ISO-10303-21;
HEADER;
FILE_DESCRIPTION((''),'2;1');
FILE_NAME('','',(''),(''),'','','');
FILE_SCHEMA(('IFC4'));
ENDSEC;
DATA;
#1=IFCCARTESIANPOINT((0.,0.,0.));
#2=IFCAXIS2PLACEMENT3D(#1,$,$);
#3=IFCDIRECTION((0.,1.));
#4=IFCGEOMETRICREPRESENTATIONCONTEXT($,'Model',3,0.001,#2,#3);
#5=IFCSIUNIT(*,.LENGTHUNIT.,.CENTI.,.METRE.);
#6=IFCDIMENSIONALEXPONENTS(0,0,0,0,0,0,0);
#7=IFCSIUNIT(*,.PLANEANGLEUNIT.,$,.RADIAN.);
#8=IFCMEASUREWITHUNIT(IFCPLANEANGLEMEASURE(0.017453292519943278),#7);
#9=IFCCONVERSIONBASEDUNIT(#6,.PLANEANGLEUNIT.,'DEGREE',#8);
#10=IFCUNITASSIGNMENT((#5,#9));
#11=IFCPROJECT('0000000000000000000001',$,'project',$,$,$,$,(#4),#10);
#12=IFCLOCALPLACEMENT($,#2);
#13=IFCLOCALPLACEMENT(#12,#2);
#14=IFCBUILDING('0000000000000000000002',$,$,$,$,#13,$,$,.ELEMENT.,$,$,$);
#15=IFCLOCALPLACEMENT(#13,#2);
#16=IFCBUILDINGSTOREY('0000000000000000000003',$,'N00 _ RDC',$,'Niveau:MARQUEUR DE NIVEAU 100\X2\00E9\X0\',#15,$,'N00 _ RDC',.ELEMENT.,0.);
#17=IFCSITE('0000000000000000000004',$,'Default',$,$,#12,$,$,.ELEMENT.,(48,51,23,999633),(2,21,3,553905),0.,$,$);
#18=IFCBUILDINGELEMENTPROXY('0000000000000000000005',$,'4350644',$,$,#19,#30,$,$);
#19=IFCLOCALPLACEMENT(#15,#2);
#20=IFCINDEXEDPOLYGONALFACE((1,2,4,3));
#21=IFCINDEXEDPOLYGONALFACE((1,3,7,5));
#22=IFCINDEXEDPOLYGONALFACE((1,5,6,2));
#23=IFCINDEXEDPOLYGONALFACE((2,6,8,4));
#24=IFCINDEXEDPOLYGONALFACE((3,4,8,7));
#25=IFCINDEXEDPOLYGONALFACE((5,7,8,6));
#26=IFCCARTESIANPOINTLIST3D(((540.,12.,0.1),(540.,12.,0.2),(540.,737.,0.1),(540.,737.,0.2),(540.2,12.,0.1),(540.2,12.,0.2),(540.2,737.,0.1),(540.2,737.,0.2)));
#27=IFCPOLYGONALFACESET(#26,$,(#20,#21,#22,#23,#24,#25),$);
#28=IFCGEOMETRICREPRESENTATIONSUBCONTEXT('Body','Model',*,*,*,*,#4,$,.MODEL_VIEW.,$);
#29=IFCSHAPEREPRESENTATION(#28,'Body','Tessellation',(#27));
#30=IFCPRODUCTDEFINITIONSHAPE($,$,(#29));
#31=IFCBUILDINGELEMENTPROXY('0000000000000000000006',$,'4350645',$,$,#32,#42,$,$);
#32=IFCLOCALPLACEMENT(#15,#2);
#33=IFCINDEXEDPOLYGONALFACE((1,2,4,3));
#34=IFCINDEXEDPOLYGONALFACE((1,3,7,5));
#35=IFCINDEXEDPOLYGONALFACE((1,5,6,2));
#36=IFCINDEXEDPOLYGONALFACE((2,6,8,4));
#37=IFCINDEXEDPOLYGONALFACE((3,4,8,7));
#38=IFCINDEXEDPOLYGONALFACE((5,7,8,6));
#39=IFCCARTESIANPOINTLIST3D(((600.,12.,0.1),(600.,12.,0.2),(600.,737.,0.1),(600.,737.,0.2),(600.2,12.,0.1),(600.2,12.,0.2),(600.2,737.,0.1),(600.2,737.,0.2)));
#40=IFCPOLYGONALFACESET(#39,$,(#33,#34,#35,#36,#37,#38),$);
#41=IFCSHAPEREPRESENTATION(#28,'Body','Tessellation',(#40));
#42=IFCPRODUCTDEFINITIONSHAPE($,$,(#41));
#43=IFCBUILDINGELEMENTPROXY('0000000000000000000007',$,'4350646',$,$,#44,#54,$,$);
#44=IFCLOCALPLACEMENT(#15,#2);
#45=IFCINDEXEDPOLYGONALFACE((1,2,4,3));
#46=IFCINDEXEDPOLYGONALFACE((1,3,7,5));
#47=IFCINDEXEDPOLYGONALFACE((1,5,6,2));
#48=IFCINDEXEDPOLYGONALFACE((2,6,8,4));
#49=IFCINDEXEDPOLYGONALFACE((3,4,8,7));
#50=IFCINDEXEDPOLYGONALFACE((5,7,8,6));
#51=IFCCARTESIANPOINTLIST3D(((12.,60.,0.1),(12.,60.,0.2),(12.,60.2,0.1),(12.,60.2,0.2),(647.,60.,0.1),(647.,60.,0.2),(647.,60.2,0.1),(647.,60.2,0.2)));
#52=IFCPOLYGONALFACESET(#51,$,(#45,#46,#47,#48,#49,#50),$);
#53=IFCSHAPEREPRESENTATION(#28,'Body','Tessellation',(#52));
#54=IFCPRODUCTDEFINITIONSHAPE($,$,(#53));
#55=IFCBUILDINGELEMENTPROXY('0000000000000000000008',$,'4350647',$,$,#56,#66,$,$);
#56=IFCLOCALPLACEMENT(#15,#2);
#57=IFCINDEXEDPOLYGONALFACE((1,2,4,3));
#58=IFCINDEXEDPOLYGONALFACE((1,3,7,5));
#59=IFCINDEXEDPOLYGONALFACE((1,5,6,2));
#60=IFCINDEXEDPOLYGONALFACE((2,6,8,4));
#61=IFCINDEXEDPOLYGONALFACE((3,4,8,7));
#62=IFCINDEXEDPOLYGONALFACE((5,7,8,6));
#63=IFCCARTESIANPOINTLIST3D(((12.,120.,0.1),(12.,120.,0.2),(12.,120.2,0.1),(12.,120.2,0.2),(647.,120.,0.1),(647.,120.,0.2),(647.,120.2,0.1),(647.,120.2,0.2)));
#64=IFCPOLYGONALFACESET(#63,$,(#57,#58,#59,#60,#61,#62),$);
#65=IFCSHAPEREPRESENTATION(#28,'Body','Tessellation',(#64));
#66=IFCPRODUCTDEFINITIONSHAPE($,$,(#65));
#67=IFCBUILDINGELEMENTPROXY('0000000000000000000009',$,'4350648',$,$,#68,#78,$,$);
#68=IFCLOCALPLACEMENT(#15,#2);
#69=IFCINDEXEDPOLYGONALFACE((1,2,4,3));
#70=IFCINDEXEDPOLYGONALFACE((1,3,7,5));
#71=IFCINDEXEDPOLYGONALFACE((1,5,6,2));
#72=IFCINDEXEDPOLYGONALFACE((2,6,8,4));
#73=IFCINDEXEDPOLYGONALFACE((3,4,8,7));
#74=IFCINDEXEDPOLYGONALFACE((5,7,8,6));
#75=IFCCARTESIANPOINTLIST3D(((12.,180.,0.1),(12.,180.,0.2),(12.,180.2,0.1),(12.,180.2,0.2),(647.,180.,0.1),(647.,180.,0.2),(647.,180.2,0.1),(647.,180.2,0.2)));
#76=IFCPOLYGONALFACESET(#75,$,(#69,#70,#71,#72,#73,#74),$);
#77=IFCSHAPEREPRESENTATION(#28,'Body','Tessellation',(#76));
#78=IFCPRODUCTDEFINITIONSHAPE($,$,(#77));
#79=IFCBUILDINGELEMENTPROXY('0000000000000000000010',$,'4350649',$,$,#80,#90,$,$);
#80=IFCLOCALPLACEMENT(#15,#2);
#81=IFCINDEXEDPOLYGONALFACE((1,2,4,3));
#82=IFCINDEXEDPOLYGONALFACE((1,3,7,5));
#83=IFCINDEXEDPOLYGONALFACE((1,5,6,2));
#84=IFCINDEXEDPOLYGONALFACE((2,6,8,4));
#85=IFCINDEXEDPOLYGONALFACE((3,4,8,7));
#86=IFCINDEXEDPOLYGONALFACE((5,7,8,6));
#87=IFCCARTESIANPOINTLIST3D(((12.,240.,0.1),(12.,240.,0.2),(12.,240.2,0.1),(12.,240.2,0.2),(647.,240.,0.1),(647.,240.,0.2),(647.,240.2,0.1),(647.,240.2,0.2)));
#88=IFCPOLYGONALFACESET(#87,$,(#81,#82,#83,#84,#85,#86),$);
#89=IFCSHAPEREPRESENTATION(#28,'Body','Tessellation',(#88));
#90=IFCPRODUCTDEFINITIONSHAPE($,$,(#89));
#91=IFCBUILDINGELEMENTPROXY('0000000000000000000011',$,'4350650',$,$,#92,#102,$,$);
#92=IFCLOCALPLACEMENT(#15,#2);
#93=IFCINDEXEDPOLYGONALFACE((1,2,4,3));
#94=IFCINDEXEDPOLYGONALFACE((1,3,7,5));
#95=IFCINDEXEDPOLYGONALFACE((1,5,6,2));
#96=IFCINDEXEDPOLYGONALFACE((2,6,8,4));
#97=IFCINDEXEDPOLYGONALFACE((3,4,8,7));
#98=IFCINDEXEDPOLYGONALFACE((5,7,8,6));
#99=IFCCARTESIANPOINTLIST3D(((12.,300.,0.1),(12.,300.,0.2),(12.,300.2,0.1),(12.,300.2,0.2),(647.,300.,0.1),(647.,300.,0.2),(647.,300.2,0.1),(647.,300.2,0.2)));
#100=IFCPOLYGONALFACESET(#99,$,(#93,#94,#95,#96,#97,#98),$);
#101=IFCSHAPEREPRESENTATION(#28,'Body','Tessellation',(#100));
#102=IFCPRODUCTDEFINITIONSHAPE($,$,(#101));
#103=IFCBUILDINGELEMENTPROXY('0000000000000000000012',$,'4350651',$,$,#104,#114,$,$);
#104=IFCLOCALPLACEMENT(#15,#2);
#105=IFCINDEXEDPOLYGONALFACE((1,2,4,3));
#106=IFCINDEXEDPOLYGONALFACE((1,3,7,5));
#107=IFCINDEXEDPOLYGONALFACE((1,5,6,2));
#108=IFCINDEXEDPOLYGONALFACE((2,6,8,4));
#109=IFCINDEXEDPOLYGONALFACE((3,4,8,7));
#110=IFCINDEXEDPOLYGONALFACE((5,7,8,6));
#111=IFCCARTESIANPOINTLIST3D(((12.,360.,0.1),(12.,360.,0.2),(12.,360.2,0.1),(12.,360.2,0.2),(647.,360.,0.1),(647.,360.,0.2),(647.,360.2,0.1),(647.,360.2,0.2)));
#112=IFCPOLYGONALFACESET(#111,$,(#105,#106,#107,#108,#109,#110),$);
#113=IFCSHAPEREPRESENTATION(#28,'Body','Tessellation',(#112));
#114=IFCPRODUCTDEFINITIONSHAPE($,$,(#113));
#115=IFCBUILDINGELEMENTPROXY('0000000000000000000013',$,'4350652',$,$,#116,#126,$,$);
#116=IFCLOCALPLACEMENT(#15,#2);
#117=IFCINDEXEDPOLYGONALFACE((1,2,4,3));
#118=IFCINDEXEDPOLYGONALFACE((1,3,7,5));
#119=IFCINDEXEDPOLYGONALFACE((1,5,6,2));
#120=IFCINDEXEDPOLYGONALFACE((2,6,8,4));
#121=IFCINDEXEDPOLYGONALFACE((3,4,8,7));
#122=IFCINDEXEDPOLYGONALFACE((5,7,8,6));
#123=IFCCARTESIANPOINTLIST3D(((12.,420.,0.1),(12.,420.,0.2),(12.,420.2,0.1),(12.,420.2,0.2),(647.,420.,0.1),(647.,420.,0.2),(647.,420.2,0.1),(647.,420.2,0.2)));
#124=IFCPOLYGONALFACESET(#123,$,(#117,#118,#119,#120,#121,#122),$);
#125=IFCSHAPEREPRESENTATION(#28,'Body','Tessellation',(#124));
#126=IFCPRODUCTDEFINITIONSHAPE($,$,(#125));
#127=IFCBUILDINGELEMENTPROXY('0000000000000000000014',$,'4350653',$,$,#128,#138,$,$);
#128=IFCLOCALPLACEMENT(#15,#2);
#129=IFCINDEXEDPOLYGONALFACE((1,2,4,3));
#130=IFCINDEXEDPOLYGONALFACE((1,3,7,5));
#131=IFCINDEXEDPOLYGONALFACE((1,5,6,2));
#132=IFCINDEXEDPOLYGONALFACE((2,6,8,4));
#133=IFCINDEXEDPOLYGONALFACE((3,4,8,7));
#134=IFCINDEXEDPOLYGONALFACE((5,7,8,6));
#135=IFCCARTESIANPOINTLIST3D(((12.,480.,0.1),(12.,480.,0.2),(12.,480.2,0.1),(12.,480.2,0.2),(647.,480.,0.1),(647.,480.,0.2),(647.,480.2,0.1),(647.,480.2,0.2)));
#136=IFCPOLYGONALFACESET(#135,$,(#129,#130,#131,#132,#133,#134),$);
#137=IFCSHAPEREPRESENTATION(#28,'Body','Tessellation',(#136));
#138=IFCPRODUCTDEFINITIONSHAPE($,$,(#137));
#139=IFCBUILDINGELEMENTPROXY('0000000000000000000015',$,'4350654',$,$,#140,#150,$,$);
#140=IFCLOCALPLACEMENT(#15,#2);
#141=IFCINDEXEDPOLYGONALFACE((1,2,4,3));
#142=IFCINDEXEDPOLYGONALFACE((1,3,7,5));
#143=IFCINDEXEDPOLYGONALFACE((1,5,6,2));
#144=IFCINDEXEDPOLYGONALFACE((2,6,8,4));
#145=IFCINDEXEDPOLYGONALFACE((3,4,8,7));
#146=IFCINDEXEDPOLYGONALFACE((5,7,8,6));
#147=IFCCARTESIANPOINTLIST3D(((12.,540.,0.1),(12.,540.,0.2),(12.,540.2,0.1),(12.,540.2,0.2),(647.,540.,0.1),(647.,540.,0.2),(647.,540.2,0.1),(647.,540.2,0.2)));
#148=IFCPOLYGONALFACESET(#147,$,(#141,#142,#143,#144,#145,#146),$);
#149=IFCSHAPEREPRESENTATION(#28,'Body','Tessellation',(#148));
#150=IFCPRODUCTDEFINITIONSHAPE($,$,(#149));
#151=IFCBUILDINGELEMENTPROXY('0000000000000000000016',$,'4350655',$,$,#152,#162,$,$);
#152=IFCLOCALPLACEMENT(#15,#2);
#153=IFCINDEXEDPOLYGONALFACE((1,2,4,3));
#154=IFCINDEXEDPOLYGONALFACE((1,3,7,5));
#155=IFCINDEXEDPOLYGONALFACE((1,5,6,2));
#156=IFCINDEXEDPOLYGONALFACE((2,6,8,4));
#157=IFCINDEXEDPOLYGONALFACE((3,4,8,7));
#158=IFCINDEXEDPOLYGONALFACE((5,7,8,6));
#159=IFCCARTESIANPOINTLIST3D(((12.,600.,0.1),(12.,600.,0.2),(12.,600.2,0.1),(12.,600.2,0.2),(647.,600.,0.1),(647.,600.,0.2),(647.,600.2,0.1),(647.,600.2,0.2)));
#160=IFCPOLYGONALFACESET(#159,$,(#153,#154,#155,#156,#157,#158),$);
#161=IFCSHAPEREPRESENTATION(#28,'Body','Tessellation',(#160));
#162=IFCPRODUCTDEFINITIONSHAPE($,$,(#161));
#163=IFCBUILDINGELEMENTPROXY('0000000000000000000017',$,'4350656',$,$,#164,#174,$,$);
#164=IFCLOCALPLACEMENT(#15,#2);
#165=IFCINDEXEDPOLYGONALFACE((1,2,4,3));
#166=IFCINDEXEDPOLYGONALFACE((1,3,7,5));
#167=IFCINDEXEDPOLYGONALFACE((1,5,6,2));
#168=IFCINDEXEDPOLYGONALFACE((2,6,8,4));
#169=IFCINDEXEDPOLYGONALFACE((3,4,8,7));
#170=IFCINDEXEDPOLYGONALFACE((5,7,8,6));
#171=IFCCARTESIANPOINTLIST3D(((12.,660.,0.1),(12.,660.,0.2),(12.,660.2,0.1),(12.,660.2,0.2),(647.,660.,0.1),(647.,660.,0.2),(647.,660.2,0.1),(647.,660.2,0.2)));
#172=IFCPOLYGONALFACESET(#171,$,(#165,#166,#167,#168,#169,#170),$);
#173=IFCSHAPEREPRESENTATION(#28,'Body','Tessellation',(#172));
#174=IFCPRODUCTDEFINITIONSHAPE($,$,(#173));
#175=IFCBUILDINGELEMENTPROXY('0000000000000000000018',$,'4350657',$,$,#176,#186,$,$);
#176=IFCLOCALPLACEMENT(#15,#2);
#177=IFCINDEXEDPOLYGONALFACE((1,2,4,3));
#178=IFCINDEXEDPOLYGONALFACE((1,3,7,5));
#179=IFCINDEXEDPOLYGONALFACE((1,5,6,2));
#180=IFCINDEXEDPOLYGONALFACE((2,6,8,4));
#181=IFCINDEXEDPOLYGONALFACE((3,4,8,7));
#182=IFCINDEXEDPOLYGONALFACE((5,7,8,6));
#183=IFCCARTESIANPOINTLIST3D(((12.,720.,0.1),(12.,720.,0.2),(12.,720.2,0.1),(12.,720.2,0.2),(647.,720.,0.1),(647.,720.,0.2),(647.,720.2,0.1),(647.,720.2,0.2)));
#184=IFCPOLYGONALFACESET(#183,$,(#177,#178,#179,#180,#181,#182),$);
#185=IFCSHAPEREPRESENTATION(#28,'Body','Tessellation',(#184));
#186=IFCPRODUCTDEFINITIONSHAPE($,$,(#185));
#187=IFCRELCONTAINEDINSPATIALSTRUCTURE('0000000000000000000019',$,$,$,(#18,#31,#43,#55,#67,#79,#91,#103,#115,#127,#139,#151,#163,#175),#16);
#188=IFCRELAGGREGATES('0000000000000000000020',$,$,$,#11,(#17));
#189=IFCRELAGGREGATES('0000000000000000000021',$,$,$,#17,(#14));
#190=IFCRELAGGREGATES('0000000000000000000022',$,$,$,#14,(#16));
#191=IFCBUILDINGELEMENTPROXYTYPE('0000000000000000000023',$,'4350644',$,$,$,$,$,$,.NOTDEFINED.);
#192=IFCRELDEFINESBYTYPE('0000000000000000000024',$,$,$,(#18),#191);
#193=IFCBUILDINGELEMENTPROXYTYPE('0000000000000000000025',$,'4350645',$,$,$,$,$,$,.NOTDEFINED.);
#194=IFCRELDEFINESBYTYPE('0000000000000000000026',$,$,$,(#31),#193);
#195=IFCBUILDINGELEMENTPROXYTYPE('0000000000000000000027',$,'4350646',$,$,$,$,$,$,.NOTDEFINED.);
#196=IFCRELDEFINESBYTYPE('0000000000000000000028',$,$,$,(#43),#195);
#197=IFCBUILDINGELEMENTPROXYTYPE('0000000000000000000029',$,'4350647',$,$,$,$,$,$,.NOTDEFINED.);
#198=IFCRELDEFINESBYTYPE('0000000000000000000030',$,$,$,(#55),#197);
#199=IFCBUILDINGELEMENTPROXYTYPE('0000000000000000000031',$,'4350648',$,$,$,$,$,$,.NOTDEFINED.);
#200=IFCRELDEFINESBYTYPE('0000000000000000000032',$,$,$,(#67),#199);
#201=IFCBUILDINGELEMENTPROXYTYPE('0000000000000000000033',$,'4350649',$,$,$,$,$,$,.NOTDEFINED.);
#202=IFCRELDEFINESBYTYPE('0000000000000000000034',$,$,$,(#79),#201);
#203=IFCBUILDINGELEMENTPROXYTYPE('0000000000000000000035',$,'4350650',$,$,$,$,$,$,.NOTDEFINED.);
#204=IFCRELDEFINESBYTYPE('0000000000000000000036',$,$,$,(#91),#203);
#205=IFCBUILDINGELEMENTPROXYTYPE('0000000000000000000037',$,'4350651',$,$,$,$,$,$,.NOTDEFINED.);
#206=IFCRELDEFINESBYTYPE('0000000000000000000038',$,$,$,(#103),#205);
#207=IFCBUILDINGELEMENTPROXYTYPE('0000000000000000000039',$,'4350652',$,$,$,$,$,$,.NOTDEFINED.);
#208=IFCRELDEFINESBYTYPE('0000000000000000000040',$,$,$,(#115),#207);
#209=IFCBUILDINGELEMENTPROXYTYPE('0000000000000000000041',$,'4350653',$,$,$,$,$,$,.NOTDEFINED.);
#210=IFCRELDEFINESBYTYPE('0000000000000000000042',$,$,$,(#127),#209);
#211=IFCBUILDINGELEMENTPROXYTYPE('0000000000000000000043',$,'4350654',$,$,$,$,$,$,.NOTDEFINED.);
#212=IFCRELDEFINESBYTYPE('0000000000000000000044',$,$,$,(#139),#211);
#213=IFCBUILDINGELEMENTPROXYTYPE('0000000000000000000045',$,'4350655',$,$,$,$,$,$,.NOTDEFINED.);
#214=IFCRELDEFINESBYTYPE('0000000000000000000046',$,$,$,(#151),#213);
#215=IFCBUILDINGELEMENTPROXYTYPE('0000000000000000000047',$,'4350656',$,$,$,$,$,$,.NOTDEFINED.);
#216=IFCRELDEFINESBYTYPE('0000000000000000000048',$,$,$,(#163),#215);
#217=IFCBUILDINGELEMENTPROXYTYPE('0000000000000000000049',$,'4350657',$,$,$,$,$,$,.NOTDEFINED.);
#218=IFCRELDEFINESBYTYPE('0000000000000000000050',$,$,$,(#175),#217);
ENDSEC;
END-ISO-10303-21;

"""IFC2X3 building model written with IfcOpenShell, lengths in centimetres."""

from ifc_helpers import new_model, entity, si_unit, converted_unit, direction, frame, frame_2d, origin, origin_2d_with_axis, place, context, subcontext, project, spatial, rectangle, extrude, type_object, element, save


model = new_model("IFC2X3")

# Units and contexts
model_context = context("Model", 3, precision=0.001, world=origin(), true_north=direction((0.0, 1.0)))
body_context = subcontext(model_context, "Body", "Model", "MODEL_VIEW")
ifc_project = project(units=[si_unit("LENGTHUNIT", "METRE", prefix="CENTI"), converted_unit("PLANEANGLEUNIT", "DEGREE", entity("IfcPlaneAngleMeasure", 0.017453292519943278), si_unit("PLANEANGLEUNIT", "RADIAN"), dimensions=[0, 0, 0, 0, 0, 0, 0])], contexts=[model_context])

# Site, building, storey
site_placement = place(None, origin())
site = spatial("IfcSite", under=ifc_project, at=site_placement, Name="Default", CompositionType="ELEMENT", RefLatitude=(48, 51, 23, 999633), RefLongitude=(2, 21, 3, 553905), RefElevation=0.0)
building_placement = place(site_placement, origin())
building = spatial("IfcBuilding", under=site, at=building_placement, CompositionType="ELEMENT")
storey_placement = place(building_placement, origin())
storey = spatial("IfcBuildingStorey", under=building, at=storey_placement, Name="N00 _ RDC", ObjectType="Niveau:MARQUEUR DE NIVEAU 100é", LongName="N00 _ RDC", CompositionType="ELEMENT", Elevation=0.0)

# Building element proxies
building_element_proxy_type_1 = type_object("IfcBuildingElementProxyType", Name="4350644", PredefinedType="NOTDEFINED")
proxy_1_placement = place(storey_placement, origin())
element("IfcBuildingElementProxy", 1, at=proxy_1_placement, inside=storey, type_object=building_element_proxy_type_1, Name="4350644", context=body_context, shape_type="SweptSolid", body=[
    extrude(rectangle(XDim=0.2, YDim=725.0, at=origin_2d_with_axis()), frame((540.1, 374.5, 0.1)), (0.0, 0.0, 1.0), 0.1),
])
building_element_proxy_type_2 = type_object("IfcBuildingElementProxyType", Name="4350645", PredefinedType="NOTDEFINED")
proxy_2_placement = place(storey_placement, origin())
element("IfcBuildingElementProxy", 2, at=proxy_2_placement, inside=storey, type_object=building_element_proxy_type_2, Name="4350645", context=body_context, shape_type="SweptSolid", body=[
    extrude(rectangle(XDim=0.2, YDim=725.0, at=origin_2d_with_axis()), frame((600.1, 374.5, 0.1)), (0.0, 0.0, 1.0), 0.1),
])
building_element_proxy_type_3 = type_object("IfcBuildingElementProxyType", Name="4350646", PredefinedType="NOTDEFINED")
proxy_3_placement = place(storey_placement, origin())
element("IfcBuildingElementProxy", 3, at=proxy_3_placement, inside=storey, type_object=building_element_proxy_type_3, Name="4350646", context=body_context, shape_type="SweptSolid", body=[
    extrude(rectangle(XDim=635.0, YDim=0.2, at=frame_2d((0.0, 0.0), x_axis=(1.0, 0.0))), frame((329.5, 60.1, 0.1)), (0.0, 0.0, 1.0), 0.1),
])
building_element_proxy_type_4 = type_object("IfcBuildingElementProxyType", Name="4350647", PredefinedType="NOTDEFINED")
proxy_4_placement = place(storey_placement, origin())
element("IfcBuildingElementProxy", 4, at=proxy_4_placement, inside=storey, type_object=building_element_proxy_type_4, Name="4350647", context=body_context, shape_type="SweptSolid", body=[
    extrude(rectangle(XDim=635.0, YDim=0.2, at=frame_2d((0.0, 0.0), x_axis=(1.0, 0.0))), frame((329.5, 120.1, 0.1)), (0.0, 0.0, 1.0), 0.1),
])
building_element_proxy_type_5 = type_object("IfcBuildingElementProxyType", Name="4350648", PredefinedType="NOTDEFINED")
proxy_5_placement = place(storey_placement, origin())
element("IfcBuildingElementProxy", 5, at=proxy_5_placement, inside=storey, type_object=building_element_proxy_type_5, Name="4350648", context=body_context, shape_type="SweptSolid", body=[
    extrude(rectangle(XDim=635.0, YDim=0.2, at=frame_2d((0.0, 0.0), x_axis=(1.0, 0.0))), frame((329.5, 180.1, 0.1)), (0.0, 0.0, 1.0), 0.1),
])
building_element_proxy_type_6 = type_object("IfcBuildingElementProxyType", Name="4350649", PredefinedType="NOTDEFINED")
proxy_6_placement = place(storey_placement, origin())
element("IfcBuildingElementProxy", 6, at=proxy_6_placement, inside=storey, type_object=building_element_proxy_type_6, Name="4350649", context=body_context, shape_type="SweptSolid", body=[
    extrude(rectangle(XDim=635.0, YDim=0.2, at=frame_2d((0.0, 0.0), x_axis=(1.0, 0.0))), frame((329.5, 240.1, 0.1)), (0.0, 0.0, 1.0), 0.1),
])
building_element_proxy_type_7 = type_object("IfcBuildingElementProxyType", Name="4350650", PredefinedType="NOTDEFINED")
proxy_7_placement = place(storey_placement, origin())
element("IfcBuildingElementProxy", 7, at=proxy_7_placement, inside=storey, type_object=building_element_proxy_type_7, Name="4350650", context=body_context, shape_type="SweptSolid", body=[
    extrude(rectangle(XDim=635.0, YDim=0.2, at=frame_2d((0.0, 0.0), x_axis=(1.0, 0.0))), frame((329.5, 300.1, 0.1)), (0.0, 0.0, 1.0), 0.1),
])
building_element_proxy_type_8 = type_object("IfcBuildingElementProxyType", Name="4350651", PredefinedType="NOTDEFINED")
proxy_8_placement = place(storey_placement, origin())
element("IfcBuildingElementProxy", 8, at=proxy_8_placement, inside=storey, type_object=building_element_proxy_type_8, Name="4350651", context=body_context, shape_type="SweptSolid", body=[
    extrude(rectangle(XDim=635.0, YDim=0.2, at=frame_2d((0.0, 0.0), x_axis=(1.0, 0.0))), frame((329.5, 360.1, 0.1)), (0.0, 0.0, 1.0), 0.1),
])
building_element_proxy_type_9 = type_object("IfcBuildingElementProxyType", Name="4350652", PredefinedType="NOTDEFINED")
proxy_9_placement = place(storey_placement, origin())
element("IfcBuildingElementProxy", 9, at=proxy_9_placement, inside=storey, type_object=building_element_proxy_type_9, Name="4350652", context=body_context, shape_type="SweptSolid", body=[
    extrude(rectangle(XDim=635.0, YDim=0.2, at=frame_2d((0.0, 0.0), x_axis=(1.0, 0.0))), frame((329.5, 420.1, 0.1)), (0.0, 0.0, 1.0), 0.1),
])
building_element_proxy_type_10 = type_object("IfcBuildingElementProxyType", Name="4350653", PredefinedType="NOTDEFINED")
proxy_10_placement = place(storey_placement, origin())
element("IfcBuildingElementProxy", 10, at=proxy_10_placement, inside=storey, type_object=building_element_proxy_type_10, Name="4350653", context=body_context, shape_type="SweptSolid", body=[
    extrude(rectangle(XDim=635.0, YDim=0.2, at=frame_2d((0.0, 0.0), x_axis=(1.0, 0.0))), frame((329.5, 480.1, 0.1)), (0.0, 0.0, 1.0), 0.1),
])
building_element_proxy_type_11 = type_object("IfcBuildingElementProxyType", Name="4350654", PredefinedType="NOTDEFINED")
proxy_11_placement = place(storey_placement, origin())
element("IfcBuildingElementProxy", 11, at=proxy_11_placement, inside=storey, type_object=building_element_proxy_type_11, Name="4350654", context=body_context, shape_type="SweptSolid", body=[
    extrude(rectangle(XDim=635.0, YDim=0.2, at=frame_2d((0.0, 0.0), x_axis=(1.0, 0.0))), frame((329.5, 540.1, 0.1)), (0.0, 0.0, 1.0), 0.1),
])
building_element_proxy_type_12 = type_object("IfcBuildingElementProxyType", Name="4350655", PredefinedType="NOTDEFINED")
proxy_12_placement = place(storey_placement, origin())
element("IfcBuildingElementProxy", 12, at=proxy_12_placement, inside=storey, type_object=building_element_proxy_type_12, Name="4350655", context=body_context, shape_type="SweptSolid", body=[
    extrude(rectangle(XDim=635.0, YDim=0.2, at=frame_2d((0.0, 0.0), x_axis=(1.0, 0.0))), frame((329.5, 600.1, 0.1)), (0.0, 0.0, 1.0), 0.1),
])
building_element_proxy_type_13 = type_object("IfcBuildingElementProxyType", Name="4350656", PredefinedType="NOTDEFINED")
proxy_13_placement = place(storey_placement, origin())
element("IfcBuildingElementProxy", 13, at=proxy_13_placement, inside=storey, type_object=building_element_proxy_type_13, Name="4350656", context=body_context, shape_type="SweptSolid", body=[
    extrude(rectangle(XDim=635.0, YDim=0.2, at=frame_2d((0.0, 0.0), x_axis=(1.0, 0.0))), frame((329.5, 660.1, 0.1)), (0.0, 0.0, 1.0), 0.1),
])
building_element_proxy_type_14 = type_object("IfcBuildingElementProxyType", Name="4350657", PredefinedType="NOTDEFINED")
proxy_14_placement = place(storey_placement, origin())
element("IfcBuildingElementProxy", 14, at=proxy_14_placement, inside=storey, type_object=building_element_proxy_type_14, Name="4350657", context=body_context, shape_type="SweptSolid", body=[
    extrude(rectangle(XDim=635.0, YDim=0.2, at=frame_2d((0.0, 0.0), x_axis=(1.0, 0.0))), frame((329.5, 720.1, 0.1)), (0.0, 0.0, 1.0), 0.1),
])

save(model, "model.ifc")
